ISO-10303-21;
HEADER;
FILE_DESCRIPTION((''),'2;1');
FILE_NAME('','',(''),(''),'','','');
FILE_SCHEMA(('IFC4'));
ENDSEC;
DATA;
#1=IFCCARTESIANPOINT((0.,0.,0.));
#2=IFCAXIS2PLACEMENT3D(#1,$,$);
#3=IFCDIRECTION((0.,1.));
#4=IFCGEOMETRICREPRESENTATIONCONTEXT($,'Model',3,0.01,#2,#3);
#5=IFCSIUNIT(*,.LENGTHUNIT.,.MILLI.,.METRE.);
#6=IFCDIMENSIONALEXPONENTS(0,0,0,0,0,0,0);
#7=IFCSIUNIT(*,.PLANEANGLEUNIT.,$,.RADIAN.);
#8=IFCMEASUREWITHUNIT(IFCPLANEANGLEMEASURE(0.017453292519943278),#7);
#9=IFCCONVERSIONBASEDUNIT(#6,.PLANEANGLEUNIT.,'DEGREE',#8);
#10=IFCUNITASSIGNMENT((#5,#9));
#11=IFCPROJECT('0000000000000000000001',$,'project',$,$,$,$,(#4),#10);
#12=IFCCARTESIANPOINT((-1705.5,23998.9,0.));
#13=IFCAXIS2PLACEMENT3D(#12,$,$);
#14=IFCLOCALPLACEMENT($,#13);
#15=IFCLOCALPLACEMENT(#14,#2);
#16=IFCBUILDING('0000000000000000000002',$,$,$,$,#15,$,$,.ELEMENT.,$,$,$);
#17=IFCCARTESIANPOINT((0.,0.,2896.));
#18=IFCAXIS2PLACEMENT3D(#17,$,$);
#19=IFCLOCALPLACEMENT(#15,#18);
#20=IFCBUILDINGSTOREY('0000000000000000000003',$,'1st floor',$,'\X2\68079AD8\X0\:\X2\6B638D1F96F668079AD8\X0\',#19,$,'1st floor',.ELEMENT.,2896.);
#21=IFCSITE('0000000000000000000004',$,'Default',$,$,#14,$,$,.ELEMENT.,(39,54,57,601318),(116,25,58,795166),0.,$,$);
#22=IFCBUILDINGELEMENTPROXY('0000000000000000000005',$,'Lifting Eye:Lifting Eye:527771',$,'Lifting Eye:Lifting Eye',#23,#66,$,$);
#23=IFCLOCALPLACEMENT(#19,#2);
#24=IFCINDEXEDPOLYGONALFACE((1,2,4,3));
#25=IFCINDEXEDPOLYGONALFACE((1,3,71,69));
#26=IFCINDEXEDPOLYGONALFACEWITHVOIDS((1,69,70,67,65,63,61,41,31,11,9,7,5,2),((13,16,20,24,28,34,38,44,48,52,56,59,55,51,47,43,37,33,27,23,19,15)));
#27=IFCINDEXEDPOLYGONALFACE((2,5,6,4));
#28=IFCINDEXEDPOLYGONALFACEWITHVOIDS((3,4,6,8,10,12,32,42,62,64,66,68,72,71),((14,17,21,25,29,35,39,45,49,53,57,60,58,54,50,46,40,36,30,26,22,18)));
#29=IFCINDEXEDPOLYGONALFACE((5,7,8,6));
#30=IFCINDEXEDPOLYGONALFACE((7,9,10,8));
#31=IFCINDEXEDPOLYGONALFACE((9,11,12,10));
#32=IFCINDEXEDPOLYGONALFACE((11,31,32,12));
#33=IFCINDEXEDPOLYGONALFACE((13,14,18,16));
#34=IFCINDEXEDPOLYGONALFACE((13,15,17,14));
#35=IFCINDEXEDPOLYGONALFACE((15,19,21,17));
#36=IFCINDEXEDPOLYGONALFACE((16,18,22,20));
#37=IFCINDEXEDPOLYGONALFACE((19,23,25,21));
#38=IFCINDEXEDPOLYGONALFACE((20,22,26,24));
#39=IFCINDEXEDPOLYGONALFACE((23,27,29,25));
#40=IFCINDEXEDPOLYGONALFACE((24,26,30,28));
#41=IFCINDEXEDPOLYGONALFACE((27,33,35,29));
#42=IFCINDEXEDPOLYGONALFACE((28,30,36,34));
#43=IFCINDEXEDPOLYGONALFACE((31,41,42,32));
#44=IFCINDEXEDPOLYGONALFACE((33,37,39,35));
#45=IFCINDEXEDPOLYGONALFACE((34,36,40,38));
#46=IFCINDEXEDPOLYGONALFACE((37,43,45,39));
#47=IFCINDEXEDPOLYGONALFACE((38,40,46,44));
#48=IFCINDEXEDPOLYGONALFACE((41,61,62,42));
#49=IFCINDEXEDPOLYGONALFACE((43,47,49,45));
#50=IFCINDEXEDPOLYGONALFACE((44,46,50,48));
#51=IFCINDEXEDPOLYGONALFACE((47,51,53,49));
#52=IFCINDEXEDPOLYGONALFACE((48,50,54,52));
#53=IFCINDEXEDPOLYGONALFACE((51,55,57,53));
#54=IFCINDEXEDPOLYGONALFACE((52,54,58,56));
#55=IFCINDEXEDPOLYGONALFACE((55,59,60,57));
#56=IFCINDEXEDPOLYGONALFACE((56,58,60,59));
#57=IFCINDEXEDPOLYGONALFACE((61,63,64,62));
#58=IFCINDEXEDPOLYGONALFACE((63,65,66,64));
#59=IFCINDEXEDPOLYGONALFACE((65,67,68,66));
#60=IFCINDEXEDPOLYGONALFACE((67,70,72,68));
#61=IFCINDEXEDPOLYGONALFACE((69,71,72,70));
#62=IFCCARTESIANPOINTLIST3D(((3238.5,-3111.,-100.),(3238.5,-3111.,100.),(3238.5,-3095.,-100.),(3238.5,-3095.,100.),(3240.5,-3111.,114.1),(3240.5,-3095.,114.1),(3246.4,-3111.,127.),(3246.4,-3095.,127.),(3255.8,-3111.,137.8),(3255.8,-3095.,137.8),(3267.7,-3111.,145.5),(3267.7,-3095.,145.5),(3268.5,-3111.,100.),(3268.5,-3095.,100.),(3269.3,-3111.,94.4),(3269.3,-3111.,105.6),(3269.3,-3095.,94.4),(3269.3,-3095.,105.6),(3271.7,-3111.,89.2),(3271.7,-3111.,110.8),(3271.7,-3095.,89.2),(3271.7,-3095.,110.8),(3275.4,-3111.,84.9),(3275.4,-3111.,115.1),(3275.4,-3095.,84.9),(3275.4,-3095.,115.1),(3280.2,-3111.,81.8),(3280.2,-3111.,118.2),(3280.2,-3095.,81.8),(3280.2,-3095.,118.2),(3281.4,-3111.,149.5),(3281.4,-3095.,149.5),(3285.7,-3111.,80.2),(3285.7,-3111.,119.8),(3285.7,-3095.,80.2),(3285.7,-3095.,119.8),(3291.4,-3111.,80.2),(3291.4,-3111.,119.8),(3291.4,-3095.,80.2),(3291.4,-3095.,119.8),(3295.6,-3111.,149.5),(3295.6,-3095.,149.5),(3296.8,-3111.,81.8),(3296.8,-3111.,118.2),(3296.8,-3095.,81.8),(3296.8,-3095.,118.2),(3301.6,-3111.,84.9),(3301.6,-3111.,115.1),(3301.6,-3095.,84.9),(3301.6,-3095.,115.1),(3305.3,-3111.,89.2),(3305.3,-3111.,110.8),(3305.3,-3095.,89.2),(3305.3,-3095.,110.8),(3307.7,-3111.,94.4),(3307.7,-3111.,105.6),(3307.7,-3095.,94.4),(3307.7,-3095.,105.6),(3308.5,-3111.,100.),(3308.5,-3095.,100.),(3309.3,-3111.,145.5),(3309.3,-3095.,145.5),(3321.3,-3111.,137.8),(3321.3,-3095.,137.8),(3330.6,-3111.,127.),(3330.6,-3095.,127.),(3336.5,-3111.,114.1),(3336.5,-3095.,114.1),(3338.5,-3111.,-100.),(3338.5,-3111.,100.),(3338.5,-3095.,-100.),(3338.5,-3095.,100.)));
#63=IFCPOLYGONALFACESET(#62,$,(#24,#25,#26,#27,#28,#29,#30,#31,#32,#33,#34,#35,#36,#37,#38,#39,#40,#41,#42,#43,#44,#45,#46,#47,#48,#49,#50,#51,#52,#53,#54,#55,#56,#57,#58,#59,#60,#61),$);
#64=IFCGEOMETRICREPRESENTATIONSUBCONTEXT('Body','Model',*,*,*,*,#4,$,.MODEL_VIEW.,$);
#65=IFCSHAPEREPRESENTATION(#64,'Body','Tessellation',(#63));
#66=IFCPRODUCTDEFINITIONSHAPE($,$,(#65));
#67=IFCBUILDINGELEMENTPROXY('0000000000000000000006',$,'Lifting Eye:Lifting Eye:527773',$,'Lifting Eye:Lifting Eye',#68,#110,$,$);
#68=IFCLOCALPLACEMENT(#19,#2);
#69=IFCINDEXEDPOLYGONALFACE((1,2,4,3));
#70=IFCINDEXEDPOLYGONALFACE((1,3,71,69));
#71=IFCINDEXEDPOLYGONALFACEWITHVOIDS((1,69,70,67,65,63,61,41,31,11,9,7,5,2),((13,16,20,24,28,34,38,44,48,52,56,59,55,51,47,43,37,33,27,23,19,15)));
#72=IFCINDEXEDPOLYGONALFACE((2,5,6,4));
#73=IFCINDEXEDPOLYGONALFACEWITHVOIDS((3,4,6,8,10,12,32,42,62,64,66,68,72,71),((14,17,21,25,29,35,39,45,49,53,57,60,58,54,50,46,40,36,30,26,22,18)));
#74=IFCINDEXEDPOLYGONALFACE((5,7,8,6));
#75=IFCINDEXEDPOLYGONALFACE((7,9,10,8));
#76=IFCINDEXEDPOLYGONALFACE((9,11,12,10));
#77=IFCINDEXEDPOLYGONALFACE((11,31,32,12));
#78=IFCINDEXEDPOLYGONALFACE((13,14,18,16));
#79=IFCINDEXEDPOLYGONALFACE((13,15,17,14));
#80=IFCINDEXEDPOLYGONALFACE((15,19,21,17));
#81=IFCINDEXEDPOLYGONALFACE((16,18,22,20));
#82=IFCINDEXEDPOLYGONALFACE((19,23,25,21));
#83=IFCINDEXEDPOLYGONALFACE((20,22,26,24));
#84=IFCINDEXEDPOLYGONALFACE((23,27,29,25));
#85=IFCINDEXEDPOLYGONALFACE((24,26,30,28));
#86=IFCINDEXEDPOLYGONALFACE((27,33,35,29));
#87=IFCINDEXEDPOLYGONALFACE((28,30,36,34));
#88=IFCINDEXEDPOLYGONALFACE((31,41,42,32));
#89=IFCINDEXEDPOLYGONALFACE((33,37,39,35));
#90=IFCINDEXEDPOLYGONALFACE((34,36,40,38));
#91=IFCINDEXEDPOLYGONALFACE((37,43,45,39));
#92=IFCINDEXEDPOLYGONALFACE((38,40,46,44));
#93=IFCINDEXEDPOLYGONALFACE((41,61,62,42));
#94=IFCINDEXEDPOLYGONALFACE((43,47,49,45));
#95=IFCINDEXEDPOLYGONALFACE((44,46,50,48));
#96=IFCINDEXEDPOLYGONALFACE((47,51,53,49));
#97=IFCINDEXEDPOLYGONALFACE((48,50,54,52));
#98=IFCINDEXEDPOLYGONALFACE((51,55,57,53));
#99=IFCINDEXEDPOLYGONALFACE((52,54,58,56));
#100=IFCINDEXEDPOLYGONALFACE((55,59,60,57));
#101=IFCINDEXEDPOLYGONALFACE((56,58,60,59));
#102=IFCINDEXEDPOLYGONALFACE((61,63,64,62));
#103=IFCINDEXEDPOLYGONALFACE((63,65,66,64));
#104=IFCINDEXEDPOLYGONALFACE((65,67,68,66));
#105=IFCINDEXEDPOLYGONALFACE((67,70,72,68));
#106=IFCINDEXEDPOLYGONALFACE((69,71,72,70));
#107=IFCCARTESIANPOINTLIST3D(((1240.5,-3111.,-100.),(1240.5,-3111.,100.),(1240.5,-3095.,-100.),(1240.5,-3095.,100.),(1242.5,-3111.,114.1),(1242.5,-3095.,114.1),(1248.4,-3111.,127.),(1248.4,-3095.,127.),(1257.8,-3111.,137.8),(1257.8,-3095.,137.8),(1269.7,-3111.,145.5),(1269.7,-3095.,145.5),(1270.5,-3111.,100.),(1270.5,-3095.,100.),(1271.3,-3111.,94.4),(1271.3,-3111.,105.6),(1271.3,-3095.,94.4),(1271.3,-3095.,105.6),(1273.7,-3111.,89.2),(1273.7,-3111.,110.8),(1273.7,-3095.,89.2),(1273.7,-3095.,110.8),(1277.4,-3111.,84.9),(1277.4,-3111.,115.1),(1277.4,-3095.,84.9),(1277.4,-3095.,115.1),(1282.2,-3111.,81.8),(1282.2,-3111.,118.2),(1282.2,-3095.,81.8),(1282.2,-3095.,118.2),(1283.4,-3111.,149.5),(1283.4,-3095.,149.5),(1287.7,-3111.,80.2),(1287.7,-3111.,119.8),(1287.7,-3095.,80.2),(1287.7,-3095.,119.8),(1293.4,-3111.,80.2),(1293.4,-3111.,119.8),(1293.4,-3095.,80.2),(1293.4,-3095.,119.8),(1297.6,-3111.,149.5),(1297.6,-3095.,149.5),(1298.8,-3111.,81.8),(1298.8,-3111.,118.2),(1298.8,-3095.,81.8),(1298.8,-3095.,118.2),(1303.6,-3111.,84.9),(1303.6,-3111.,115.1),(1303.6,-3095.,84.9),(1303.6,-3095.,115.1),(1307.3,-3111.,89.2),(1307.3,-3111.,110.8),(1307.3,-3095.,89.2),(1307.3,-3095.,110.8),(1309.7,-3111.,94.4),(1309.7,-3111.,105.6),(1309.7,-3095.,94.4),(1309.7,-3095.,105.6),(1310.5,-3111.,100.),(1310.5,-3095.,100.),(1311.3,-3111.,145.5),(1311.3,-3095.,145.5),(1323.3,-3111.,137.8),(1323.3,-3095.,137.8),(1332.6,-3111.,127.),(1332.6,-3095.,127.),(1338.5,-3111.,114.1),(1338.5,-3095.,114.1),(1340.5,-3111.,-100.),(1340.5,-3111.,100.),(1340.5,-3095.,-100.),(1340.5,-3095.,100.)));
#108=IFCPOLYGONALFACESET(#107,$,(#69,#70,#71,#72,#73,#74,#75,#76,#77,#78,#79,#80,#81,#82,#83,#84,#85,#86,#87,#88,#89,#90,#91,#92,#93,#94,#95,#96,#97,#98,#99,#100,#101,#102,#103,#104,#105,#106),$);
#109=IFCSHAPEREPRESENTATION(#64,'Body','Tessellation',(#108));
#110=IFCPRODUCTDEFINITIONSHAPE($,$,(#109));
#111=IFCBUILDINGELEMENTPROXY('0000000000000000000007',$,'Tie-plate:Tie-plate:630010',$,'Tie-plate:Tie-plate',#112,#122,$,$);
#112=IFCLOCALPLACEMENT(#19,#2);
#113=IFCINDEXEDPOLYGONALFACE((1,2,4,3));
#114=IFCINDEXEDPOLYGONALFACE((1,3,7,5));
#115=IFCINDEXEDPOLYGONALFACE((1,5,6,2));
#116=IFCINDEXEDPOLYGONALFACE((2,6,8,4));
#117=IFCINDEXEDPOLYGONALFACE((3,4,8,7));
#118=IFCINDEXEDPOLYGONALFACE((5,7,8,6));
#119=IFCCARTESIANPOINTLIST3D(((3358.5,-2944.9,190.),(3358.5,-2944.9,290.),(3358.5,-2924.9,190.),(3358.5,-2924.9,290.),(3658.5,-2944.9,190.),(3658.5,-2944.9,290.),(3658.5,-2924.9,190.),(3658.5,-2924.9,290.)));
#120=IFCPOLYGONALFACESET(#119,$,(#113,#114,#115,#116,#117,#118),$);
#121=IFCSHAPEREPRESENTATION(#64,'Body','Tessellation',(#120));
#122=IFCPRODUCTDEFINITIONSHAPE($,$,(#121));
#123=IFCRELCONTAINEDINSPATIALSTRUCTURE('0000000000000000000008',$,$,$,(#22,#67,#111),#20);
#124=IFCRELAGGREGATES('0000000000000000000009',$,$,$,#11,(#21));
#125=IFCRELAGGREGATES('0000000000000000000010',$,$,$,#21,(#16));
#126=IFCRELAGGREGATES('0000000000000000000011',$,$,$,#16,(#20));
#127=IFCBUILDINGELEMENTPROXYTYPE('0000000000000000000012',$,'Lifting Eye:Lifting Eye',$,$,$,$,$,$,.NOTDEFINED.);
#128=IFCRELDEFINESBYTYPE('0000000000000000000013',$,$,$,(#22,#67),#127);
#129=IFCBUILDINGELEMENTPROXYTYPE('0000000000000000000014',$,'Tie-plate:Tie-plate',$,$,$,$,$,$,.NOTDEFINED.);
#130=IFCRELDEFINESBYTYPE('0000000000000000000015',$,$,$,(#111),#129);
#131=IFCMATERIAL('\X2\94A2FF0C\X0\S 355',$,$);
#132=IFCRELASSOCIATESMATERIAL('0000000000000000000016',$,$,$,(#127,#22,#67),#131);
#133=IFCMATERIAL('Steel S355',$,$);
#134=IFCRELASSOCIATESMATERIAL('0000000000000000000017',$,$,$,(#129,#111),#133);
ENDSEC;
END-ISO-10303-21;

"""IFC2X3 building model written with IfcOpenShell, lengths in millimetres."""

from ifc_helpers import new_model, entity, si_unit, converted_unit, direction, frame, frame_2d, origin, place, context, subcontext, project, spatial, polyline, circle_curve, parameter, trimmed, segment, composite_curve, rectangle, outline, extrude, source, transform, mapped, material, type_object, type_shapes, element, save


model = new_model("IFC2X3")

# Units and contexts
model_context = context("Model", 3, precision=0.01, world=origin(), true_north=direction((0.0, 1.0)))
body_context = subcontext(model_context, "Body", "Model", "MODEL_VIEW")
ifc_project = project(units=[si_unit("LENGTHUNIT", "METRE", prefix="MILLI"), converted_unit("PLANEANGLEUNIT", "DEGREE", entity("IfcPlaneAngleMeasure", 0.017453292519943278), si_unit("PLANEANGLEUNIT", "RADIAN"), dimensions=[0, 0, 0, 0, 0, 0, 0])], contexts=[model_context])

# Site, building, storey
site_placement = place(None, frame((-1705.5, 23998.9, 0.0)))
site = spatial("IfcSite", under=ifc_project, at=site_placement, Name="Default", CompositionType="ELEMENT", RefLatitude=(39, 54, 57, 601318), RefLongitude=(116, 25, 58, 795166), RefElevation=0.0)
building_placement = place(site_placement, origin())
building = spatial("IfcBuilding", under=site, at=building_placement, CompositionType="ELEMENT")
storey_placement = place(building_placement, frame((0.0, 0.0, 2896.0)))
storey = spatial("IfcBuildingStorey", under=building, at=storey_placement, Name="1st floor", ObjectType="标高:正负零标高", LongName="1st floor", CompositionType="ELEMENT", Elevation=2896.0)

# Shared definitions
ifc_material_1 = material(Name="Steel S355")

# Building element proxies
ifc_material_2 = material(Name="钢，S 355")
building_element_proxy_type_1 = type_object("IfcBuildingElementProxyType", Name="Lifting Eye:Lifting Eye", PredefinedType="NOTDEFINED", material=ifc_material_2)
shared_shape_1 = source(origin(), body_context, "Body", "SweptSolid", [
    extrude(outline(composite_curve([segment(polyline([(-100.0, -50.0), (100.0, -50.0)]), True, "CONTINUOUS"), segment(polyline([(100.0, -50.0), (100.0, 50.0)]), True, "CONTINUOUS"), segment(polyline([(100.0, 50.0), (-100.0, 50.0)]), True, "CONTINUOUS"), segment(trimmed(circle_curve(frame_2d((-100.0, 0.0), x_axis=(0.0, -1.0)), 50.0), [parameter(180.0)], [parameter(0.0)], True, "PARAMETER"), True, "CONTINUOUS")], self_intersect=False), holes=[composite_curve([segment(trimmed(circle_curve(frame_2d((-100.0, 0.0), x_axis=(0.0, -1.0)), 20.0), [parameter(180.0)], [parameter(360.0)], True, "PARAMETER"), False, "CONTINUOUS"), segment(trimmed(circle_curve(frame_2d((-100.0, 0.0), x_axis=(0.0, -1.0)), 20.0), [parameter(0.0)], [parameter(180.0)], True, "PARAMETER"), False, "CONTINUOUS")], self_intersect=False)]), frame((0.0, 17.0, -17.0), z_axis=(0.0, 1.0, 0.0), x_axis=(0.0, 0.0, -1.0)), (0.0, 0.0, 1.0), 16.0),
])
type_shapes(building_element_proxy_type_1, [shared_shape_1])
for number, where, name in (
    (1, (3288.5, -3128.0, 17.0), "Lifting Eye:Lifting Eye:527771"),
    (2, (1290.5, -3128.0, 17.0), "Lifting Eye:Lifting Eye:527773"),
):
    element("IfcBuildingElementProxy", number, at=place(storey_placement, frame(where)), inside=storey, type_object=building_element_proxy_type_1, material=ifc_material_2, Name=name, ObjectType="Lifting Eye:Lifting Eye", context=body_context, shape_type="MappedRepresentation", body=[
        mapped(shared_shape_1, transform((0.0, 0.0, 0.0), scale=1.0)),
    ])
building_element_proxy_type_2 = type_object("IfcBuildingElementProxyType", Name="Tie-plate:Tie-plate", PredefinedType="NOTDEFINED", material=ifc_material_1)
shared_shape_2 = source(origin(), body_context, "Body", "SweptSolid", [
    extrude(rectangle(XDim=20.0, YDim=300.0, at=frame_2d((0.0, 0.0), x_axis=(1.0, 0.0))), frame((150.0, 10.0, 0.0), z_axis=(0.0, 0.0, 1.0), x_axis=(0.0, 1.0, 0.0)), (0.0, 0.0, 1.0), 100.0),
])
type_shapes(building_element_proxy_type_2, [shared_shape_2])
proxy_placement = place(storey_placement, frame((3358.5, -2944.9, 190.0)))
element("IfcBuildingElementProxy", 3, at=proxy_placement, inside=storey, type_object=building_element_proxy_type_2, material=ifc_material_1, Name="Tie-plate:Tie-plate:630010", ObjectType="Tie-plate:Tie-plate", context=body_context, shape_type="MappedRepresentation", body=[
    mapped(shared_shape_2, transform((0.0, 0.0, 0.0), scale=1.0)),
])

save(model, "model.ifc")
